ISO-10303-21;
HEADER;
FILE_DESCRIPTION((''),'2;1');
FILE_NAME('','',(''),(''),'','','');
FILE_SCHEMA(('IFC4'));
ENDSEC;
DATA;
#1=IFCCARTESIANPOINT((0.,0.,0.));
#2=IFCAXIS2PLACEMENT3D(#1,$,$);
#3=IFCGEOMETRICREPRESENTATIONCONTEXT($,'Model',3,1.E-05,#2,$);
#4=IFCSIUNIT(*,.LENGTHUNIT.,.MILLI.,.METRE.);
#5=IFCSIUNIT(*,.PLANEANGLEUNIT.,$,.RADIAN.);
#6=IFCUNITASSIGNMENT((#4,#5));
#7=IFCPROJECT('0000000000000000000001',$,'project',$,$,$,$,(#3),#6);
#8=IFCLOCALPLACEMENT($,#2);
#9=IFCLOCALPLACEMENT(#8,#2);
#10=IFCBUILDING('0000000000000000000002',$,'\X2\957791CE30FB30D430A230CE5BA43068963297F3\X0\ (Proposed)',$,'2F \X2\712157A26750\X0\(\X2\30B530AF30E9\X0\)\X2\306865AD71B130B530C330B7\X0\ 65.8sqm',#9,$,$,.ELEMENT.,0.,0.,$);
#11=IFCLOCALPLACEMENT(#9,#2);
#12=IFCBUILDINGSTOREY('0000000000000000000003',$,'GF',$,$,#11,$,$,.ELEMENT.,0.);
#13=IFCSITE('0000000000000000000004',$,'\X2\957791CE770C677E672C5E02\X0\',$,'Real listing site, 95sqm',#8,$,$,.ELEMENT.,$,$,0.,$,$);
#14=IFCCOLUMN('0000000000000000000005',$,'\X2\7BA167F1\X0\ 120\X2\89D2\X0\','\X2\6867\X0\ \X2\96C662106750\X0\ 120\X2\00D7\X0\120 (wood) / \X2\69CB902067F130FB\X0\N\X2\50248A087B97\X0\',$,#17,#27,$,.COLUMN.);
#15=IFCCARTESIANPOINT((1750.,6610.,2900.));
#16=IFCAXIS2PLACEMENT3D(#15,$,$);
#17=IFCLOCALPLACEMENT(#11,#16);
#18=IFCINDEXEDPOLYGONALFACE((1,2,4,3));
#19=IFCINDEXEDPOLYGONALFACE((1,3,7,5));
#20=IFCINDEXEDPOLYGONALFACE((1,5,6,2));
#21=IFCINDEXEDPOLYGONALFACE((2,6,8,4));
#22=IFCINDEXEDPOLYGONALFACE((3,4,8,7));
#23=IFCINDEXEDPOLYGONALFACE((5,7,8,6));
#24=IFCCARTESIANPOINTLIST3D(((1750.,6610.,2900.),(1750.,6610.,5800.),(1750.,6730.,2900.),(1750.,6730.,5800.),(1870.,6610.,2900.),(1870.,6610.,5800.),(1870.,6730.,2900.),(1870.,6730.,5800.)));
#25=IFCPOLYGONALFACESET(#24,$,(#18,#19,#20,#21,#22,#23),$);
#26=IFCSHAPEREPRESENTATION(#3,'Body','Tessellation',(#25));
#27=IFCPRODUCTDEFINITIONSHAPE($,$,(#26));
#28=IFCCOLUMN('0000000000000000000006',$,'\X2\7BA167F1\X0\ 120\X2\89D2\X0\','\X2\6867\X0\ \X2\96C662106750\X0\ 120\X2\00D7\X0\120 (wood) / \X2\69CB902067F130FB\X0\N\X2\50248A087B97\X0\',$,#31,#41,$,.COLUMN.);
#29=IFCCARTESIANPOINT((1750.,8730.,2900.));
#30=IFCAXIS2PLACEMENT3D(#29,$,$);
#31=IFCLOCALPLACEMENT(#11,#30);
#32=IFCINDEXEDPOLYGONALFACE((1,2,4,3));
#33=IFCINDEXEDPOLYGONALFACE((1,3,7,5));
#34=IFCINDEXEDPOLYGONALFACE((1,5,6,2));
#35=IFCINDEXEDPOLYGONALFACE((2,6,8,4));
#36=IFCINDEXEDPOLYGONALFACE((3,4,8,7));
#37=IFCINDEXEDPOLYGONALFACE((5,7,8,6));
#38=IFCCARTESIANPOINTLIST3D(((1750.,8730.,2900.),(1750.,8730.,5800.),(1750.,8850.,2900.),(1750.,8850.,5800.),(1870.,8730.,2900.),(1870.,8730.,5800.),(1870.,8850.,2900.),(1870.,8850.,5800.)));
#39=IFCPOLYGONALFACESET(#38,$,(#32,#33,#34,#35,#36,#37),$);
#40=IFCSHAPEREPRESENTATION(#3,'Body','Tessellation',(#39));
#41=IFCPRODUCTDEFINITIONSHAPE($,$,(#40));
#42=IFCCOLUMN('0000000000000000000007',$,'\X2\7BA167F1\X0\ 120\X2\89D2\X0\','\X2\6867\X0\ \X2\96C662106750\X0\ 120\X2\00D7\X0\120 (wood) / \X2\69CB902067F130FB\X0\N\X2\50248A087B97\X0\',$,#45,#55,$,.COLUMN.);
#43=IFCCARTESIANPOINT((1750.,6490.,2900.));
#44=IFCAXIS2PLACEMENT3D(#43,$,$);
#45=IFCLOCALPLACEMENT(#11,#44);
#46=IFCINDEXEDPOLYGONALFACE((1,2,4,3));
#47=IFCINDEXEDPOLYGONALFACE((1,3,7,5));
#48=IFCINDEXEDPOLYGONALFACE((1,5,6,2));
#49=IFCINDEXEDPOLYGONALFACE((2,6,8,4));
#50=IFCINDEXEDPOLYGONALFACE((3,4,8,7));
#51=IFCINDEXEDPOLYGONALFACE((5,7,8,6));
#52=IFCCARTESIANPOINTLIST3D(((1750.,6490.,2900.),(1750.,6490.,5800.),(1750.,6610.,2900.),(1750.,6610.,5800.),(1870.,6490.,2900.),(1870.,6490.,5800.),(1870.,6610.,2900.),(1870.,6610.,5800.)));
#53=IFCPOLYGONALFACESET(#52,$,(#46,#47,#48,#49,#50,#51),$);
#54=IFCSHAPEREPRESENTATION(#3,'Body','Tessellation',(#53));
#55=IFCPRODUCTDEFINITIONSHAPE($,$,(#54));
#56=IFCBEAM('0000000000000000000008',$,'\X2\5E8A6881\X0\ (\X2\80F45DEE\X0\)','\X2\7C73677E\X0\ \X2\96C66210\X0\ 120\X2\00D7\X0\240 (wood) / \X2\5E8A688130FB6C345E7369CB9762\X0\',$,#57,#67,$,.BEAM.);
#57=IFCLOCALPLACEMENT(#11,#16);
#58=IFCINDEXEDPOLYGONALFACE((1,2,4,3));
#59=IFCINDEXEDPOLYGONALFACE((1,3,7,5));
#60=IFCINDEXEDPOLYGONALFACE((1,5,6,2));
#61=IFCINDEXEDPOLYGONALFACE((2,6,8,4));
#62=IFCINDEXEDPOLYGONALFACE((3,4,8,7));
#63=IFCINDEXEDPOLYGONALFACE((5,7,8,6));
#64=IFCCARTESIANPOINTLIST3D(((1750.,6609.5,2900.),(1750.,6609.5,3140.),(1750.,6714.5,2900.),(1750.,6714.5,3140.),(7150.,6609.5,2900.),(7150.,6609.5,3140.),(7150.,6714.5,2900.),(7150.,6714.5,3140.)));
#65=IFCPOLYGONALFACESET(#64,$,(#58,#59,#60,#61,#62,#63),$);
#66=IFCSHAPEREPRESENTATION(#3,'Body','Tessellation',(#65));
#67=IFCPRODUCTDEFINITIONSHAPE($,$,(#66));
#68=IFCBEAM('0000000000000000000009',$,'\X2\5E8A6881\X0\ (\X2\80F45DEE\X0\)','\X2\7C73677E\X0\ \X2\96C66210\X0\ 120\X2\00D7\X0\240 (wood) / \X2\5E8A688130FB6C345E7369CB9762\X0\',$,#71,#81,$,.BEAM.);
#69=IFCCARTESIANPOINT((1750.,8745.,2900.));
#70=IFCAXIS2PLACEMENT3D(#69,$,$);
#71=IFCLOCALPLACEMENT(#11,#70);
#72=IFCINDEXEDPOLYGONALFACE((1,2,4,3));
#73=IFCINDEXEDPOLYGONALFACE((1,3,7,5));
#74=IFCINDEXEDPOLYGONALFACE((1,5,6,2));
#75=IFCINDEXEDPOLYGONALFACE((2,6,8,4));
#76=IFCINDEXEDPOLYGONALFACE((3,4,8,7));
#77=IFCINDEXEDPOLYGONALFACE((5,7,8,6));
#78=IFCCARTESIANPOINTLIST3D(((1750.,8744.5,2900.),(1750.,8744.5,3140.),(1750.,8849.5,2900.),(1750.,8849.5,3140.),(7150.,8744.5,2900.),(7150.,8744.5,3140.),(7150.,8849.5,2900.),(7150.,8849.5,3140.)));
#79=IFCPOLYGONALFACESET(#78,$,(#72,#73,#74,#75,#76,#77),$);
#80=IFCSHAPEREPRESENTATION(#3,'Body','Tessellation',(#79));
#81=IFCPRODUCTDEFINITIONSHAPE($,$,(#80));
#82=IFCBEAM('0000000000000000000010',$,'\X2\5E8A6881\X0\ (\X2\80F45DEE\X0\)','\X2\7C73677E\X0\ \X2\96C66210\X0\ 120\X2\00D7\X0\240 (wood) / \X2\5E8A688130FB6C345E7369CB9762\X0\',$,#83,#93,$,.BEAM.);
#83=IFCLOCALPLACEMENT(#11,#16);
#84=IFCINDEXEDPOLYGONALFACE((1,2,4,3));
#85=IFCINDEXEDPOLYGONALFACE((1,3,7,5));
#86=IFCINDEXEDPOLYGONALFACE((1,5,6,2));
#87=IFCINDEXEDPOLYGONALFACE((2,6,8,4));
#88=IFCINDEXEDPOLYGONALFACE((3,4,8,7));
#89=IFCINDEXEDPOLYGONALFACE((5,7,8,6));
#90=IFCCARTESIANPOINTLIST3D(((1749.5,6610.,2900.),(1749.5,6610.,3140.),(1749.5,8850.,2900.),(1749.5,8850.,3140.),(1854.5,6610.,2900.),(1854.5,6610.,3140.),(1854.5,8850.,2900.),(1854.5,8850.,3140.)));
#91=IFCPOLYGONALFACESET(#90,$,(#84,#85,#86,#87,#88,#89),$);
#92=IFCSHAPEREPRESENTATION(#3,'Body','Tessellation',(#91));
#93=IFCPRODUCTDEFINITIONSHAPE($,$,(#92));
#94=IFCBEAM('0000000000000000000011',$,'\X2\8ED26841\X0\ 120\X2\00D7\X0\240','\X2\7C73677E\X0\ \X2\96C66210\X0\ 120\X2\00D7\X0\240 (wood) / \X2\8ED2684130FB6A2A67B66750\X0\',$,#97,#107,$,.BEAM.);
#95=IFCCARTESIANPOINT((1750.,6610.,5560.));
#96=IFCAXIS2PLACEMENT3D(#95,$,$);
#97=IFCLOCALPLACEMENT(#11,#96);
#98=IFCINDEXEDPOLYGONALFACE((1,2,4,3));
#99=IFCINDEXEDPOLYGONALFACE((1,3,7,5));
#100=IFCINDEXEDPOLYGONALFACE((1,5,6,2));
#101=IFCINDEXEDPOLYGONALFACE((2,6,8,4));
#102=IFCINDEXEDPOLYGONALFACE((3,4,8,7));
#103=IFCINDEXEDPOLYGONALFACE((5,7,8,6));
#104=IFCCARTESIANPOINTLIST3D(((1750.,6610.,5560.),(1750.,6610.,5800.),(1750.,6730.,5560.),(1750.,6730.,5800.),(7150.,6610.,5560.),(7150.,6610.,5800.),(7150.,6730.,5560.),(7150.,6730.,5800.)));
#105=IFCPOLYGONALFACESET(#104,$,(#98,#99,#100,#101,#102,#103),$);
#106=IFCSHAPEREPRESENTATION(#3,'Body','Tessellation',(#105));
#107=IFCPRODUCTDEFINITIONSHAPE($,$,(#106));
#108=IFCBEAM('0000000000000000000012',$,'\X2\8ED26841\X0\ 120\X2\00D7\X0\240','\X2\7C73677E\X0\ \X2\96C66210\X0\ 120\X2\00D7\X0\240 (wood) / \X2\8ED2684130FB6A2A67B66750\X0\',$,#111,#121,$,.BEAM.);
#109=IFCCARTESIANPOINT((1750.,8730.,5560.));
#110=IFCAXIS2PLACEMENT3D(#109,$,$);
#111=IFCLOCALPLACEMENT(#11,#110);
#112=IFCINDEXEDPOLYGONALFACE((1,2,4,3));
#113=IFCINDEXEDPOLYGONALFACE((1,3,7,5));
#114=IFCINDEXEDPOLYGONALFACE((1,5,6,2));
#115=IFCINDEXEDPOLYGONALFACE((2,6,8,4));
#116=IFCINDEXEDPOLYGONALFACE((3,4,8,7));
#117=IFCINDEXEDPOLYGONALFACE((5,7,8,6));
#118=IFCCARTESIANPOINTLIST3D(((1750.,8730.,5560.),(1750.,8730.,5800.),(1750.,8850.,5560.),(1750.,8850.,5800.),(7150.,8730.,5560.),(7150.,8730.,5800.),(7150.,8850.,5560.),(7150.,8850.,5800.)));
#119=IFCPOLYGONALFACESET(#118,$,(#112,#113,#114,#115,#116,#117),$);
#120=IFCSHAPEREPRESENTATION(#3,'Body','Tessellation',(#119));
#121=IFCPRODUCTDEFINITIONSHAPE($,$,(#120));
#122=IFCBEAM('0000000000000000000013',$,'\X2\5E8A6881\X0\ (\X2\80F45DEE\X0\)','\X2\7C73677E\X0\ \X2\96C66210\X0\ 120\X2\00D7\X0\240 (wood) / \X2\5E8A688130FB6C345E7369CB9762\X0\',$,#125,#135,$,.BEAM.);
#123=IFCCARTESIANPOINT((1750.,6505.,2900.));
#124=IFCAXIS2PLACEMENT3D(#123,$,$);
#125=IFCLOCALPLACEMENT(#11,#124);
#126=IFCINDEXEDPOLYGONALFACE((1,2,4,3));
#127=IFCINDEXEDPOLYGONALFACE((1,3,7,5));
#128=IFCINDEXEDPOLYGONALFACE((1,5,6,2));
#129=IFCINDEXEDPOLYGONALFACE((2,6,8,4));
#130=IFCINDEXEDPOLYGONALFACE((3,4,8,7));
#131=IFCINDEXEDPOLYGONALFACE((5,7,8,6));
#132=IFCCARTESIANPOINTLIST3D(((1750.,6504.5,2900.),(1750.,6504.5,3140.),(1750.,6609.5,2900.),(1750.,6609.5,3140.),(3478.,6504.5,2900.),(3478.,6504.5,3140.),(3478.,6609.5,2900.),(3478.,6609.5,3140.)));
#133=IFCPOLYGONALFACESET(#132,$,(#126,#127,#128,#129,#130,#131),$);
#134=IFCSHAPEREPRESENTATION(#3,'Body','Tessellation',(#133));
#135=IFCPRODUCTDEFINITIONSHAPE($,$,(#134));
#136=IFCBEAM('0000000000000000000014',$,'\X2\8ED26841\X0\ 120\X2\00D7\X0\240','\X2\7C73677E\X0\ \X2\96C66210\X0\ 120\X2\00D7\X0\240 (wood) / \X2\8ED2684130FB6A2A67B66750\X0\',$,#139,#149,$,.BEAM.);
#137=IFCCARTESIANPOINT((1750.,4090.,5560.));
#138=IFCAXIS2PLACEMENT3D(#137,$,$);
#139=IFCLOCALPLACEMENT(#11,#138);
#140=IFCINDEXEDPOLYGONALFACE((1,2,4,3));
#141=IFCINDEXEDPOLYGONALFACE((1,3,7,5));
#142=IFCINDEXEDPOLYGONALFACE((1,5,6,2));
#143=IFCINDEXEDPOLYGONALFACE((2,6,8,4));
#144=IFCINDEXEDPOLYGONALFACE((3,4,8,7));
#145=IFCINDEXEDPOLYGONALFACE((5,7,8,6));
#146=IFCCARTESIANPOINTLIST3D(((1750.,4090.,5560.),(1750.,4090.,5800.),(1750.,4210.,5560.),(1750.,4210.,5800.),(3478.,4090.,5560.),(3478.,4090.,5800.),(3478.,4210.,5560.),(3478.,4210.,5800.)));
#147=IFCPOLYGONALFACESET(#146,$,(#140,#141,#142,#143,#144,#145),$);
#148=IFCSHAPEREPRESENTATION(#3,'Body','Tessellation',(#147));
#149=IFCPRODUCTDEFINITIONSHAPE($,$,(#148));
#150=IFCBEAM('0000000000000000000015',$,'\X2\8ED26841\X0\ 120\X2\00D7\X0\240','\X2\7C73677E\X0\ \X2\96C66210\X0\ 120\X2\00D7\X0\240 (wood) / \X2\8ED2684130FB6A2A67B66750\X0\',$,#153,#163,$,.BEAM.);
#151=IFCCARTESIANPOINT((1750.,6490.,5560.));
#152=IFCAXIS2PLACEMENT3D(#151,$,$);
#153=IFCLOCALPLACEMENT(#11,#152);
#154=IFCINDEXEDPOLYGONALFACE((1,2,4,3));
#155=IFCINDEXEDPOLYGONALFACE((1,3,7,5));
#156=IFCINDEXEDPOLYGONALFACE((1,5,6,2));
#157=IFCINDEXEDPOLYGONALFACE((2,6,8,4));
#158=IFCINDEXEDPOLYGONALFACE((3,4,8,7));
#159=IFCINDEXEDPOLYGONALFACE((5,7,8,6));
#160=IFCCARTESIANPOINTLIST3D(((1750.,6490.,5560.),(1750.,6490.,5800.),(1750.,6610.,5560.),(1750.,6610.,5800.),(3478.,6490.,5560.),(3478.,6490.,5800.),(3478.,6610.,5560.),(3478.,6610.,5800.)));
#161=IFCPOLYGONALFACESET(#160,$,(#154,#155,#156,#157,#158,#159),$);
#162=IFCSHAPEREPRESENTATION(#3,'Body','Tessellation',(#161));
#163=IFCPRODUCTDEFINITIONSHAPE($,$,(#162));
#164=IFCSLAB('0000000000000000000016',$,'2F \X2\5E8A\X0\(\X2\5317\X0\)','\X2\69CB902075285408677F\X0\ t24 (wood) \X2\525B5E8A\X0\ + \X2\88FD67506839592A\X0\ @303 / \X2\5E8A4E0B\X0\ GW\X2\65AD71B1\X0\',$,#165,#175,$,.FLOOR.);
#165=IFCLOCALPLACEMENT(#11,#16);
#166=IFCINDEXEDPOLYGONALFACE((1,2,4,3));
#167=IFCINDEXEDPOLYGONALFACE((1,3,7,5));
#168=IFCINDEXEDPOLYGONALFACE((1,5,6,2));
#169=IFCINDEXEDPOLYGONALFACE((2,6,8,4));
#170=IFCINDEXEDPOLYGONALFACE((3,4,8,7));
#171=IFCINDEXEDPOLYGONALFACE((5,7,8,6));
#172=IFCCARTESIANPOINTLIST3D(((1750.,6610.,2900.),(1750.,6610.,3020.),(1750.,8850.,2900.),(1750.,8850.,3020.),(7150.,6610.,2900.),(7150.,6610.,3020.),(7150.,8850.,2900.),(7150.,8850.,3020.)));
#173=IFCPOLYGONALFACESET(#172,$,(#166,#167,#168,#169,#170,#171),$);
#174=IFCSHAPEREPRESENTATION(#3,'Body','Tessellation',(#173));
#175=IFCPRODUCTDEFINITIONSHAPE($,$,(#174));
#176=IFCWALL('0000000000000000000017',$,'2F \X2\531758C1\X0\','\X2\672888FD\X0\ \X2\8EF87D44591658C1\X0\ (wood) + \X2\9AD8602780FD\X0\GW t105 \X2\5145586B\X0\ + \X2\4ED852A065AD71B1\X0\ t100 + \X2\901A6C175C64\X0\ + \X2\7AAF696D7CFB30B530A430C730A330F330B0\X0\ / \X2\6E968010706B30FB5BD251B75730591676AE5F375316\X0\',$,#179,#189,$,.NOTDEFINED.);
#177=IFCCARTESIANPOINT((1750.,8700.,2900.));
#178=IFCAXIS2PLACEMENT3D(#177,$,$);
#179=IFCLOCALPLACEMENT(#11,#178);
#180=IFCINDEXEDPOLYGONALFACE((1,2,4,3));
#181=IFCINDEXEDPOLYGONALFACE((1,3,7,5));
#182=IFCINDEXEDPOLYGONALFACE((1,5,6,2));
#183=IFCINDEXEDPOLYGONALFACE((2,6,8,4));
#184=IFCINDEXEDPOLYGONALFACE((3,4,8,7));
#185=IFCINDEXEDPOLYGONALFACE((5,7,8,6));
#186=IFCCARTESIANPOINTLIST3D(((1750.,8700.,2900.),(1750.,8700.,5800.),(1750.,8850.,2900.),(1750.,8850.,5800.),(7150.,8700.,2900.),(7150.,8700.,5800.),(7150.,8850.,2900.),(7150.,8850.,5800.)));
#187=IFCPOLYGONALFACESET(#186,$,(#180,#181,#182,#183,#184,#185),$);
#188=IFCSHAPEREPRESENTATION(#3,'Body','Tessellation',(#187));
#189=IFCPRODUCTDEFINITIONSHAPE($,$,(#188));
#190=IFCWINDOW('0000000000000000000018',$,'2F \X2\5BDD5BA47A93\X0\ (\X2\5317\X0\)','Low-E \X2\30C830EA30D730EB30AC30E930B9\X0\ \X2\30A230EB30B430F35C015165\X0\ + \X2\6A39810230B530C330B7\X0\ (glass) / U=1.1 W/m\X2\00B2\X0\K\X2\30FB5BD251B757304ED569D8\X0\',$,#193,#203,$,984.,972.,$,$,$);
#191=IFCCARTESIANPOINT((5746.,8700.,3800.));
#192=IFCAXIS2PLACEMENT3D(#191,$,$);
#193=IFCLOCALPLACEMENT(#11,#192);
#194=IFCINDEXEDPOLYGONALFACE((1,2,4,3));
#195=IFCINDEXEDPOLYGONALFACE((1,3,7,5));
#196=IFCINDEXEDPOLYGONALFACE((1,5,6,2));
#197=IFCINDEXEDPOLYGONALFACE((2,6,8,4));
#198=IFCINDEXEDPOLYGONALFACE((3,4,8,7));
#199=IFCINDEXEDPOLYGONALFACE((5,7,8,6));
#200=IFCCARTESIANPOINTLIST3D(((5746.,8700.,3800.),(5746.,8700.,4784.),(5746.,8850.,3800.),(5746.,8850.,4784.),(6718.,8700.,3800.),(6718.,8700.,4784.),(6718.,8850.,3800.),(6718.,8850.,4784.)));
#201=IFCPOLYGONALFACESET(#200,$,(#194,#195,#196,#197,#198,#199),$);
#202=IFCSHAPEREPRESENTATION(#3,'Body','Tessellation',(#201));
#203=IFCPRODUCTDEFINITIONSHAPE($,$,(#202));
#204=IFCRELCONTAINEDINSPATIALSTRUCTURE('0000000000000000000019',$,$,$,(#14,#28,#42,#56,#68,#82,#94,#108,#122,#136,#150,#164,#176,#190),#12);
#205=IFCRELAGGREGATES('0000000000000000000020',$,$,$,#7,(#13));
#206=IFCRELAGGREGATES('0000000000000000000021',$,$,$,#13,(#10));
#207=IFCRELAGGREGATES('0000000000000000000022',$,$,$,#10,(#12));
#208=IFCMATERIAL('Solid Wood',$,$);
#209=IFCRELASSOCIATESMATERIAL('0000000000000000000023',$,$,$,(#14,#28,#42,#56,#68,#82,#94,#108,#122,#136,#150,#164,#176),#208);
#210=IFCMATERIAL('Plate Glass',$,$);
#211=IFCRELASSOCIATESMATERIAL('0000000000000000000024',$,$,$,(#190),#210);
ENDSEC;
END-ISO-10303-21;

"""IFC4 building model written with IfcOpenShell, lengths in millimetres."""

from ifc_helpers import new_model, si_unit, frame, frame_2d, origin, place, context, project, spatial, rectangle, extrude, material, element, fill, save


model = new_model("IFC4")

# Units and contexts
model_context = context("Model", 3, precision=1e-05, world=origin())
ifc_project = project(units=[si_unit("LENGTHUNIT", "METRE", prefix="MILLI"), si_unit("PLANEANGLEUNIT", "RADIAN")], contexts=[model_context])

# Site, building, storey
site_placement = place(None, origin())
site = spatial("IfcSite", under=ifc_project, at=site_placement, Name="長野県松本市", ObjectType="Real listing site, 95sqm", CompositionType="ELEMENT", RefElevation=0.0)
building_placement = place(site_placement, origin())
building = spatial("IfcBuilding", under=site, at=building_placement, Name="長野・ピアノ室と防音 (Proposed)", ObjectType="2F 無垢材(サクラ)と断熱サッシ 65.8sqm", CompositionType="ELEMENT", ElevationOfRefHeight=0.0, ElevationOfTerrain=0.0)
storey_placement = place(building_placement, origin())
storey = spatial("IfcBuildingStorey", under=building, at=storey_placement, Name="GF", CompositionType="ELEMENT", Elevation=0.0)

# Columns
ifc_material_1 = material(Name="Solid Wood")
column_1_placement = place(storey_placement, frame((1750.0, 6610.0, 2900.0)))
element("IfcColumn", 1, at=column_1_placement, inside=storey, material=ifc_material_1, Name="管柱 120角", Description="桧 集成材 120×120 (wood) / 構造柱・N値計算", PredefinedType="COLUMN", context=model_context, shape_type="SweptSolid", body=[
    extrude(rectangle(XDim=120.0, YDim=120.0, at=frame_2d((60.0, 60.0))), frame((1750.0, 6610.0, 2900.0)), (0.0, 0.0, 1.0), 2900.0),
])
column_2_placement = place(storey_placement, frame((1750.0, 8730.0, 2900.0)))
element("IfcColumn", 2, at=column_2_placement, inside=storey, material=ifc_material_1, Name="管柱 120角", Description="桧 集成材 120×120 (wood) / 構造柱・N値計算", PredefinedType="COLUMN", context=model_context, shape_type="SweptSolid", body=[
    extrude(rectangle(XDim=120.0, YDim=120.0, at=frame_2d((60.0, 60.0))), frame((1750.0, 8730.0, 2900.0)), (0.0, 0.0, 1.0), 2900.0),
])
column_3_placement = place(storey_placement, frame((1750.0, 6490.0, 2900.0)))
element("IfcColumn", 3, at=column_3_placement, inside=storey, material=ifc_material_1, Name="管柱 120角", Description="桧 集成材 120×120 (wood) / 構造柱・N値計算", PredefinedType="COLUMN", context=model_context, shape_type="SweptSolid", body=[
    extrude(rectangle(XDim=120.0, YDim=120.0, at=frame_2d((60.0, 60.0))), frame((1750.0, 6490.0, 2900.0)), (0.0, 0.0, 1.0), 2900.0),
])

# Beams
beam_1_placement = place(storey_placement, frame((1750.0, 6610.0, 2900.0)))
element("IfcBeam", 4, at=beam_1_placement, inside=storey, material=ifc_material_1, Name="床梁 (胴差)", Description="米松 集成 120×240 (wood) / 床梁・水平構面", PredefinedType="BEAM", context=model_context, shape_type="SweptSolid", body=[
    extrude(rectangle(XDim=5400.0, YDim=105.0, at=frame_2d((2700.0, 52.0))), frame((1750.0, 6610.0, 2900.0)), (0.0, 0.0, 1.0), 240.0),
])
beam_2_placement = place(storey_placement, frame((1750.0, 8745.0, 2900.0)))
element("IfcBeam", 5, at=beam_2_placement, inside=storey, material=ifc_material_1, Name="床梁 (胴差)", Description="米松 集成 120×240 (wood) / 床梁・水平構面", PredefinedType="BEAM", context=model_context, shape_type="SweptSolid", body=[
    extrude(rectangle(XDim=5400.0, YDim=105.0, at=frame_2d((2700.0, 52.0))), frame((1750.0, 8745.0, 2900.0)), (0.0, 0.0, 1.0), 240.0),
])
beam_3_placement = place(storey_placement, frame((1750.0, 6610.0, 2900.0)))
element("IfcBeam", 6, at=beam_3_placement, inside=storey, material=ifc_material_1, Name="床梁 (胴差)", Description="米松 集成 120×240 (wood) / 床梁・水平構面", PredefinedType="BEAM", context=model_context, shape_type="SweptSolid", body=[
    extrude(rectangle(XDim=105.0, YDim=2240.0, at=frame_2d((52.0, 1120.0))), frame((1750.0, 6610.0, 2900.0)), (0.0, 0.0, 1.0), 240.0),
])
beam_4_placement = place(storey_placement, frame((1750.0, 6610.0, 5560.0)))
element("IfcBeam", 7, at=beam_4_placement, inside=storey, material=ifc_material_1, Name="軒桁 120×240", Description="米松 集成 120×240 (wood) / 軒桁・横架材", PredefinedType="BEAM", context=model_context, shape_type="SweptSolid", body=[
    extrude(rectangle(XDim=5400.0, YDim=120.0, at=frame_2d((2700.0, 60.0))), frame((1750.0, 6610.0, 5560.0)), (0.0, 0.0, 1.0), 240.0),
])
beam_5_placement = place(storey_placement, frame((1750.0, 8730.0, 5560.0)))
element("IfcBeam", 8, at=beam_5_placement, inside=storey, material=ifc_material_1, Name="軒桁 120×240", Description="米松 集成 120×240 (wood) / 軒桁・横架材", PredefinedType="BEAM", context=model_context, shape_type="SweptSolid", body=[
    extrude(rectangle(XDim=5400.0, YDim=120.0, at=frame_2d((2700.0, 60.0))), frame((1750.0, 8730.0, 5560.0)), (0.0, 0.0, 1.0), 240.0),
])
beam_6_placement = place(storey_placement, frame((1750.0, 6505.0, 2900.0)))
element("IfcBeam", 9, at=beam_6_placement, inside=storey, material=ifc_material_1, Name="床梁 (胴差)", Description="米松 集成 120×240 (wood) / 床梁・水平構面", PredefinedType="BEAM", context=model_context, shape_type="SweptSolid", body=[
    extrude(rectangle(XDim=1728.0, YDim=105.0, at=frame_2d((864.0, 52.0))), frame((1750.0, 6505.0, 2900.0)), (0.0, 0.0, 1.0), 240.0),
])
beam_7_placement = place(storey_placement, frame((1750.0, 4090.0, 5560.0)))
element("IfcBeam", 10, at=beam_7_placement, inside=storey, material=ifc_material_1, Name="軒桁 120×240", Description="米松 集成 120×240 (wood) / 軒桁・横架材", PredefinedType="BEAM", context=model_context, shape_type="SweptSolid", body=[
    extrude(rectangle(XDim=1728.0, YDim=120.0, at=frame_2d((864.0, 60.0))), frame((1750.0, 4090.0, 5560.0)), (0.0, 0.0, 1.0), 240.0),
])
beam_8_placement = place(storey_placement, frame((1750.0, 6490.0, 5560.0)))
element("IfcBeam", 11, at=beam_8_placement, inside=storey, material=ifc_material_1, Name="軒桁 120×240", Description="米松 集成 120×240 (wood) / 軒桁・横架材", PredefinedType="BEAM", context=model_context, shape_type="SweptSolid", body=[
    extrude(rectangle(XDim=1728.0, YDim=120.0, at=frame_2d((864.0, 60.0))), frame((1750.0, 6490.0, 5560.0)), (0.0, 0.0, 1.0), 240.0),
])

# Slab
slab_placement = place(storey_placement, frame((1750.0, 6610.0, 2900.0)))
element("IfcSlab", 12, at=slab_placement, inside=storey, material=ifc_material_1, Name="2F 床(北)", Description="構造用合板 t24 (wood) 剛床 + 製材根太 @303 / 床下 GW断熱", PredefinedType="FLOOR", context=model_context, shape_type="SweptSolid", body=[
    extrude(rectangle(XDim=5400.0, YDim=2240.0, at=frame_2d((2700.0, 1120.0))), frame((1750.0, 6610.0, 2900.0)), (0.0, 0.0, 1.0), 120.0),
])

# Wall, opening, window
wall_placement = place(storey_placement, frame((1750.0, 8700.0, 2900.0)))
wall = element("IfcWall", 13, at=wall_placement, inside=storey, material=ifc_material_1, Name="2F 北壁", Description="木製 軸組外壁 (wood) + 高性能GW t105 充填 + 付加断熱 t100 + 通気層 + 窯業系サイディング / 準耐火・寒冷地外皮強化", PredefinedType="NOTDEFINED", context=model_context, shape_type="SweptSolid", body=[
    extrude(rectangle(XDim=5400.0, YDim=150.0, at=frame_2d((2700.0, 75.0))), frame((1750.0, 8700.0, 2900.0)), (0.0, 0.0, 1.0), 2900.0),
])
opening_placement = place(storey_placement, frame((5746.0, 8700.0, 3800.0)))
opening = element("IfcOpeningElement", 14, at=opening_placement, cuts=wall, PredefinedType="NOTDEFINED", context=model_context, shape_type="SweptSolid", body=[
    extrude(rectangle(XDim=972.0, YDim=150.0, at=frame_2d((486.0, 75.0))), frame((5746.0, 8700.0, 3800.0)), (0.0, 0.0, 1.0), 984.0),
])
ifc_material_2 = material(Name="Plate Glass")
window_placement = place(storey_placement, frame((5746.0, 8700.0, 3800.0)))
window = element("IfcWindow", 15, at=window_placement, inside=storey, material=ifc_material_2, Name="2F 寝室窓 (北)", Description="Low-E トリプルガラス アルゴン封入 + 樹脂サッシ (glass) / U=1.1 W/m²K・寒冷地仕様", OverallHeight=984.0, OverallWidth=972.0, context=model_context, shape_type="SweptSolid", body=[
    extrude(rectangle(XDim=972.0, YDim=150.0, at=frame_2d((486.0, 75.0))), frame((5746.0, 8700.0, 3800.0)), (0.0, 0.0, 1.0), 984.0),
])
fill(opening, window)

save(model, "model.ifc")
